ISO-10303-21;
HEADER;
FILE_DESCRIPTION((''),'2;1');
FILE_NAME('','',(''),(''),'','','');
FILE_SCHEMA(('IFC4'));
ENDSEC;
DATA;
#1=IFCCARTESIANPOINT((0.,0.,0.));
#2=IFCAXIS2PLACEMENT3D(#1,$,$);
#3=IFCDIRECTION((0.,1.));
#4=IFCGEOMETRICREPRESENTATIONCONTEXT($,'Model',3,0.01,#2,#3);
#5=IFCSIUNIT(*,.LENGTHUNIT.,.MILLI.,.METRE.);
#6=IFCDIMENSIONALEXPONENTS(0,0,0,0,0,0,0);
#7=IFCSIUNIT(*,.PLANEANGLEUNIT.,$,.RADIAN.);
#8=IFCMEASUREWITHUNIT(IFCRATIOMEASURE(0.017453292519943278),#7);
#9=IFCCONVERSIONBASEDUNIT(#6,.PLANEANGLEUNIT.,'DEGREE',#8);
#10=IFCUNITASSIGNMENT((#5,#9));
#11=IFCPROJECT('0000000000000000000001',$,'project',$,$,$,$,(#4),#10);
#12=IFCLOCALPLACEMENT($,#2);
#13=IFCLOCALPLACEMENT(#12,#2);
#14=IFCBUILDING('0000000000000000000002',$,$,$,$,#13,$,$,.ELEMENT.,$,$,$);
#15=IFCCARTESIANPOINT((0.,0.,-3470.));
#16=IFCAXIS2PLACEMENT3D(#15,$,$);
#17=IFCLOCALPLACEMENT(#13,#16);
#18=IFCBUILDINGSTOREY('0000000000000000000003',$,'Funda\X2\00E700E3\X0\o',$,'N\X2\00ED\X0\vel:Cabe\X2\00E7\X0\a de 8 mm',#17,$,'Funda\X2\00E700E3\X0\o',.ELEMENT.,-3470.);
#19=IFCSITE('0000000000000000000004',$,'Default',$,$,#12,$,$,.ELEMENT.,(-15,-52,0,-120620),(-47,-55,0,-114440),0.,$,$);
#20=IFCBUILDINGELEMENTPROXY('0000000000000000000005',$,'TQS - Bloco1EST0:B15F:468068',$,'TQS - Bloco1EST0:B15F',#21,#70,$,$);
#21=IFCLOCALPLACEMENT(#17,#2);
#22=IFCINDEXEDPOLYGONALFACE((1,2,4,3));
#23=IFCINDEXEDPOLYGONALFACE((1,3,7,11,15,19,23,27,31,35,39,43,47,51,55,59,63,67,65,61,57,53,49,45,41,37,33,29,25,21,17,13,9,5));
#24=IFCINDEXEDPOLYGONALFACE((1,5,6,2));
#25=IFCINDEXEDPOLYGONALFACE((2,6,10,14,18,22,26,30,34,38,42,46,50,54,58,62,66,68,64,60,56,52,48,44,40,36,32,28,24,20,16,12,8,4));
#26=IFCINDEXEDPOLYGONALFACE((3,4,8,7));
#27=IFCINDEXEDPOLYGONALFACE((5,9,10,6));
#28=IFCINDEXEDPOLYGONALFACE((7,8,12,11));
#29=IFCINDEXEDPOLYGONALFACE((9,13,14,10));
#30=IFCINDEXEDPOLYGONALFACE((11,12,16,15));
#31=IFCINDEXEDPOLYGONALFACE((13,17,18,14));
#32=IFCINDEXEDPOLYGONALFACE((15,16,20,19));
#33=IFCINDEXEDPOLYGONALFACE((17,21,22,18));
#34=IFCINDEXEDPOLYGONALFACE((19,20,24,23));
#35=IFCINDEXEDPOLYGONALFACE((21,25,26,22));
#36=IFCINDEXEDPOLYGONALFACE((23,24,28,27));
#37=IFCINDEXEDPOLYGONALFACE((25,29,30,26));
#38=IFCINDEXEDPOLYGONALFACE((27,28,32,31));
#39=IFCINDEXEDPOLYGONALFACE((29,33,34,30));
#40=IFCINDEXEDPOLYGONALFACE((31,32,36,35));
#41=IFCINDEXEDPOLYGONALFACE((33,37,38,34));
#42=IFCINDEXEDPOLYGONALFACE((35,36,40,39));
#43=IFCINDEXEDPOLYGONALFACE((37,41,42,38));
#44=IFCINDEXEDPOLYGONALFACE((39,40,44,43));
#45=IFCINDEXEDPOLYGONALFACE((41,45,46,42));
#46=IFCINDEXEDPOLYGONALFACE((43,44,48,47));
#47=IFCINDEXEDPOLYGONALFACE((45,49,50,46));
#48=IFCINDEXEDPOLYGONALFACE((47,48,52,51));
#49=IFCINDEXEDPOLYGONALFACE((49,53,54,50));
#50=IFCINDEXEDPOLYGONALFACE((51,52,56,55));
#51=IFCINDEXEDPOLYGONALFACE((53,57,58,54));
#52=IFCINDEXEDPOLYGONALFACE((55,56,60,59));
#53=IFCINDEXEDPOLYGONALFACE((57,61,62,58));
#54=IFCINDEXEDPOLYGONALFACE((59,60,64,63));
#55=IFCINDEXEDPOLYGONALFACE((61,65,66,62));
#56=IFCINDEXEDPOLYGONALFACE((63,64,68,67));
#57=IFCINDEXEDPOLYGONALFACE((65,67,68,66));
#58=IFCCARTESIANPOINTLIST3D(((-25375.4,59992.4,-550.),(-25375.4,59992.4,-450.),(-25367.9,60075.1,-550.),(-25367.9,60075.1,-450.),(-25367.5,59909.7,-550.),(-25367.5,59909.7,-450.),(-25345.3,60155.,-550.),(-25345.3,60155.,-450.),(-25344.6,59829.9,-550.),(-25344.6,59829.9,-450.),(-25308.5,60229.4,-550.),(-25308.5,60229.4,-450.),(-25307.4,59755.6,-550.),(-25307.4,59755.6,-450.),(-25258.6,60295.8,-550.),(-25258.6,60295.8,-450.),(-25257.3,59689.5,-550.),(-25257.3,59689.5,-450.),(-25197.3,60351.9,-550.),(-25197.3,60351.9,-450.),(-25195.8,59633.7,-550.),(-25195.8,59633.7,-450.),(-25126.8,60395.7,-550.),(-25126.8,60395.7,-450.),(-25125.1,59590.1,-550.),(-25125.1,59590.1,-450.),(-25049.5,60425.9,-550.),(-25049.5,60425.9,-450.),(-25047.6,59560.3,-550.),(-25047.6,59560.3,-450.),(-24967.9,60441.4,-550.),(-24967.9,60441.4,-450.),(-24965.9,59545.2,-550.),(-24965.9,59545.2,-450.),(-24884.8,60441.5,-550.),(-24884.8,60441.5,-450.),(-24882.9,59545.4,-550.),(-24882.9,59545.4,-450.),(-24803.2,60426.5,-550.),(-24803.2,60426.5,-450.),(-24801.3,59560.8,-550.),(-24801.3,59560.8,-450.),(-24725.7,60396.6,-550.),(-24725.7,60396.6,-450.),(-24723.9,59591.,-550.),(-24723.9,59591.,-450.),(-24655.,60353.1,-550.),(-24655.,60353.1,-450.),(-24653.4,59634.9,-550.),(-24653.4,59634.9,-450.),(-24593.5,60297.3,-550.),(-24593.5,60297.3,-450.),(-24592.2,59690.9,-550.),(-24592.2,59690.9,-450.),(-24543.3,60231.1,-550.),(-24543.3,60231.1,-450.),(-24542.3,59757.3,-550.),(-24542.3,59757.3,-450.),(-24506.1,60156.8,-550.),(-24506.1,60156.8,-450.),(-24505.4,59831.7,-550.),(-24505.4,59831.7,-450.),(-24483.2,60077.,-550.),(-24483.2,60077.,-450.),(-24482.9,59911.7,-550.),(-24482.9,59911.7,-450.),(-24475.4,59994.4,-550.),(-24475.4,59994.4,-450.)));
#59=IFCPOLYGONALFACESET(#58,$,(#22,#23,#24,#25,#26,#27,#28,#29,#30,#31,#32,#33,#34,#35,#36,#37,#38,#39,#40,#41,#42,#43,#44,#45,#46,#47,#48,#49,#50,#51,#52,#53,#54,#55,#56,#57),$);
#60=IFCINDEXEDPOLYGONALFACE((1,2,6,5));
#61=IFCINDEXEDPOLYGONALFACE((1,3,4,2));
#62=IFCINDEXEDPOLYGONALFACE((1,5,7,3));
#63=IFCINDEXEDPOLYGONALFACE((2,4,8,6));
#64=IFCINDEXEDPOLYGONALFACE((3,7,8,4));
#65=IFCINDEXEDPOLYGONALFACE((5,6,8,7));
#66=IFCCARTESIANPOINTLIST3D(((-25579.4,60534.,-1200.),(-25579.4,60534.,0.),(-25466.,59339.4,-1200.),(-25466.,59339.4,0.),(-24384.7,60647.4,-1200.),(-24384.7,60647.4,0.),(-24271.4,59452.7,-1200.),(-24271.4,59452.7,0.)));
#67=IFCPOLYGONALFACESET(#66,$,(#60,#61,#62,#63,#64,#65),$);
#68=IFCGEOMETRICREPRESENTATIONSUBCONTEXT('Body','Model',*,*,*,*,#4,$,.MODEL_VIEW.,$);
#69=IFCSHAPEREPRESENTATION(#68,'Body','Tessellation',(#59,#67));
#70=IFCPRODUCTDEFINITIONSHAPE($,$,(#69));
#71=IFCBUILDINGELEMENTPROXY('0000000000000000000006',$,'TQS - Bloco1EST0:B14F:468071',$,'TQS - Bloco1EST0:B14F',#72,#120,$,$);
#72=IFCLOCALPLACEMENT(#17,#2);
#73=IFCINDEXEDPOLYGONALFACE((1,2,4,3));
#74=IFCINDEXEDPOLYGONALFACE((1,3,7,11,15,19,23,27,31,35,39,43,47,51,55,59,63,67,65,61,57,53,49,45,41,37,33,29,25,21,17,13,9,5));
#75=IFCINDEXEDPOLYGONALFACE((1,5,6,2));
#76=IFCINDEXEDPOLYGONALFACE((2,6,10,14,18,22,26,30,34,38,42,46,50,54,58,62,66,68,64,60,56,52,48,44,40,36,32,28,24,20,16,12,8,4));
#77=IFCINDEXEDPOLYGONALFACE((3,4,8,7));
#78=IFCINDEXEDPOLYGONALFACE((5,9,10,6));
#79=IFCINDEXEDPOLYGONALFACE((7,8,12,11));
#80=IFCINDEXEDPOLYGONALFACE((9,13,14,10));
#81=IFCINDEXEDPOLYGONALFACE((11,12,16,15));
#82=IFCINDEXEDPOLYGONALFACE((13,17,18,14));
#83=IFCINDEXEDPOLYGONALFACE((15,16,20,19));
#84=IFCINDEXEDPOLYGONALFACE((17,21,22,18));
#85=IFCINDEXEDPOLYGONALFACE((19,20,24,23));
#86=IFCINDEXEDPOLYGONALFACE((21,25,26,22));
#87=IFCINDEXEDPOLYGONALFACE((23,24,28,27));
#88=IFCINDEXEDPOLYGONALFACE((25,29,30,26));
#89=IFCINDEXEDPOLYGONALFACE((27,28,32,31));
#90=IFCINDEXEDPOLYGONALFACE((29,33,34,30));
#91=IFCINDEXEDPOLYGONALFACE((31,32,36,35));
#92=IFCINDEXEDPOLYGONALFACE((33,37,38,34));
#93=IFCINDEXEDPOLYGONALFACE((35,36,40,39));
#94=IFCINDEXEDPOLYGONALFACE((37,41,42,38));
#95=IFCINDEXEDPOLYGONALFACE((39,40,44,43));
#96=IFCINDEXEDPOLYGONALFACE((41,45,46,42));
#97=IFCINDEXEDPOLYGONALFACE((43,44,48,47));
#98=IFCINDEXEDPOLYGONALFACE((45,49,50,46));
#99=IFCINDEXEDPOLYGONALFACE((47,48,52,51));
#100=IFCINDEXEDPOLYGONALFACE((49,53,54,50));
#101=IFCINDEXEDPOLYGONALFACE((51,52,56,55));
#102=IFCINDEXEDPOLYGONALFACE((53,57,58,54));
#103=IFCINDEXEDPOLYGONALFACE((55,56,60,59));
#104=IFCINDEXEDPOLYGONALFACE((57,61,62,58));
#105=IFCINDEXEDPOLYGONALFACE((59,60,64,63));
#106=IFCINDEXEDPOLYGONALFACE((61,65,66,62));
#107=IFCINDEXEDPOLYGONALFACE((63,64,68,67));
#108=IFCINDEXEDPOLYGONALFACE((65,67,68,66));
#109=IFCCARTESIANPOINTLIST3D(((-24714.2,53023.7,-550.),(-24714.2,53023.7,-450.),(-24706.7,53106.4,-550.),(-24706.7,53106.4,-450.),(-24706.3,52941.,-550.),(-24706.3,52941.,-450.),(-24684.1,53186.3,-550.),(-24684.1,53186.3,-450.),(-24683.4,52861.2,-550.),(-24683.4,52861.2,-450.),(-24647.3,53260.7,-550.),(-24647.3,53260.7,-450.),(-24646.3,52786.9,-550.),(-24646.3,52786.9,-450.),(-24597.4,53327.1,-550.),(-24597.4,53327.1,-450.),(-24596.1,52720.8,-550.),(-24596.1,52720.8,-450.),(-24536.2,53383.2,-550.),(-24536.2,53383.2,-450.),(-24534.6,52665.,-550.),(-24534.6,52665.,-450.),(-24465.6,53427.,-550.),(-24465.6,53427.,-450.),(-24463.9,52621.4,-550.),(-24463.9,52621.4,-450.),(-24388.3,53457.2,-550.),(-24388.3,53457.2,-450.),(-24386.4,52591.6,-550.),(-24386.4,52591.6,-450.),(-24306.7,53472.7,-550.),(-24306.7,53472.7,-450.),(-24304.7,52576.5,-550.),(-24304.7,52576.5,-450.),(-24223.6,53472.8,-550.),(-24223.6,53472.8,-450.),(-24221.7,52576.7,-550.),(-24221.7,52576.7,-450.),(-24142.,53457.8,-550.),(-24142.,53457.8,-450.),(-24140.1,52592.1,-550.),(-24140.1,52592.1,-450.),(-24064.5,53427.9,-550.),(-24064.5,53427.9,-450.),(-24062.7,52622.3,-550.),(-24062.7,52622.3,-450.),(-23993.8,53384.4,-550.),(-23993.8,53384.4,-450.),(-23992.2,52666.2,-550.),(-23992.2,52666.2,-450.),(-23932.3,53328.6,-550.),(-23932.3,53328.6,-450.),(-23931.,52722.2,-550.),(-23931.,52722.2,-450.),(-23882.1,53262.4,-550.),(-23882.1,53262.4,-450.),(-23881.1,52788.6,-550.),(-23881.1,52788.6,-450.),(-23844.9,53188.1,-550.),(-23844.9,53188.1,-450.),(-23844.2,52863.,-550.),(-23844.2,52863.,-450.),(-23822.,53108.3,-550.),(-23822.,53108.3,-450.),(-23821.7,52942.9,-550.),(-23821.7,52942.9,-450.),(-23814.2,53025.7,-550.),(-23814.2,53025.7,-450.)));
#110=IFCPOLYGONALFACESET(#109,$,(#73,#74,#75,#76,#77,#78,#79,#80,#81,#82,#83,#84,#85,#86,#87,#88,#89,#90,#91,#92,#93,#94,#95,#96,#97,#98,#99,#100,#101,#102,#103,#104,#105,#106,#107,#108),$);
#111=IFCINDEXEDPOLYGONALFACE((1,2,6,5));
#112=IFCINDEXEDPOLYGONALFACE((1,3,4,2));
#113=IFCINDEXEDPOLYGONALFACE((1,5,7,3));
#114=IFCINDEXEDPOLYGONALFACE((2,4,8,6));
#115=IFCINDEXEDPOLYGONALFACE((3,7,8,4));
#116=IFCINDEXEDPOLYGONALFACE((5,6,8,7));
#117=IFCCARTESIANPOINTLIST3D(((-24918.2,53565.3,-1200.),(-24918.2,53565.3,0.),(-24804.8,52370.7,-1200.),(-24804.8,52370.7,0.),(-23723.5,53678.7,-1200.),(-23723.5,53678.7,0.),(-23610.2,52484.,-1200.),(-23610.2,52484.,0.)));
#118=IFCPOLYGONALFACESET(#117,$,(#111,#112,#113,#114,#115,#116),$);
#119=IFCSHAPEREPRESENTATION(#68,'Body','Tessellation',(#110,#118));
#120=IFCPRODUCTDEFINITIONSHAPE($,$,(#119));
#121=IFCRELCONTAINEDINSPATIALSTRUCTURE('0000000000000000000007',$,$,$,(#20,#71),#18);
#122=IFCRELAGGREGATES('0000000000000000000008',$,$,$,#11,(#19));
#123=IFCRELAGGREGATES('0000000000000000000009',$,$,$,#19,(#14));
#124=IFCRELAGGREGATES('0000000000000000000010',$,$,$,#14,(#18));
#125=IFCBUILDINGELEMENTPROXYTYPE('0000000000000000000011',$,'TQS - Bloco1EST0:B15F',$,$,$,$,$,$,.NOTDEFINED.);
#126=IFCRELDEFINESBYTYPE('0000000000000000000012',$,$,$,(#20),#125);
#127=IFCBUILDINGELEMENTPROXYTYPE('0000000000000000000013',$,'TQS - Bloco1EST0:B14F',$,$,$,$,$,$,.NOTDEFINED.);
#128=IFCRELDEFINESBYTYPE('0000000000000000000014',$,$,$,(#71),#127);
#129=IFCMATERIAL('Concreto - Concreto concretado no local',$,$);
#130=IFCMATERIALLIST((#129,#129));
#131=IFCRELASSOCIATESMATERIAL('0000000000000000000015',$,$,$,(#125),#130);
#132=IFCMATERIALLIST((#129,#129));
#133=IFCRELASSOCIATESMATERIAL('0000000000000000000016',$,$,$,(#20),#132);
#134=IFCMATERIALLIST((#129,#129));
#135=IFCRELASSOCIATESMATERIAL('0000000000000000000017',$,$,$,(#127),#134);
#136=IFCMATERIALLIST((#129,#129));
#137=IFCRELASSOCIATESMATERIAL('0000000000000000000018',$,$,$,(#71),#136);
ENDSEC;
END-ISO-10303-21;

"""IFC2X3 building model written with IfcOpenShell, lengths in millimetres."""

from ifc_helpers import new_model, entity, si_unit, converted_unit, direction, frame, frame_2d, origin, origin_2d_with_axis, place, context, subcontext, project, spatial, rectangle, circle, extrude, source, transform, mapped, material, material_list, type_object, type_shapes, element, save


model = new_model("IFC2X3")

# Units and contexts
model_context = context("Model", 3, precision=0.01, world=origin(), true_north=direction((0.0, 1.0)))
body_context = subcontext(model_context, "Body", "Model", "MODEL_VIEW")
ifc_project = project(units=[si_unit("LENGTHUNIT", "METRE", prefix="MILLI"), converted_unit("PLANEANGLEUNIT", "DEGREE", entity("IfcRatioMeasure", 0.017453292519943278), si_unit("PLANEANGLEUNIT", "RADIAN"), dimensions=[0, 0, 0, 0, 0, 0, 0])], contexts=[model_context])

# Site, building, storey
site_placement = place(None, origin())
site = spatial("IfcSite", under=ifc_project, at=site_placement, Name="Default", CompositionType="ELEMENT", RefLatitude=(-15, -52, 0, -120620), RefLongitude=(-47, -55, 0, -114440), RefElevation=0.0)
building_placement = place(site_placement, origin())
building = spatial("IfcBuilding", under=site, at=building_placement, CompositionType="ELEMENT")
storey_placement = place(building_placement, frame((0.0, 0.0, -3470.0)))
storey = spatial("IfcBuildingStorey", under=building, at=storey_placement, Name="Fundação", ObjectType="Nível:Cabeça de 8 mm", LongName="Fundação", CompositionType="ELEMENT", Elevation=-3470.0)

# Building element proxies
ifc_material_1 = material(Name="Concreto - Concreto concretado no local")
ifc_material_list_1 = material_list([ifc_material_1, ifc_material_1])
ifc_material_list_2 = material_list([ifc_material_1, ifc_material_1])
building_element_proxy_type_1 = type_object("IfcBuildingElementProxyType", Name="TQS - Bloco1EST0:B15F", PredefinedType="NOTDEFINED", material=ifc_material_list_2)
shared_shape_1 = source(origin(), body_context, "Body", "SweptSolid", [
    extrude(circle(Radius=450.0, at=frame_2d((0.0, 0.0), x_axis=(1.0, 0.0))), frame((0.0, 0.0, -550.0)), (0.0, 0.0, 1.0), 100.0),
    extrude(rectangle(XDim=1200.0, YDim=1200.0, at=origin_2d_with_axis()), frame((0.0, 0.0, -1200.0), z_axis=(0.0, 0.0, 1.0), x_axis=(-1.0, 0.0, 0.0)), (0.0, 0.0, 1.0), 1200.0),
])
type_shapes(building_element_proxy_type_1, [shared_shape_1])
proxy_1_placement = place(storey_placement, frame((-24925.4, 59993.4, 0.0), z_axis=(0.0, 0.0, 1.0), x_axis=(-0.094456, 0.995529, 0.0)))
element("IfcBuildingElementProxy", 1, at=proxy_1_placement, inside=storey, type_object=building_element_proxy_type_1, material=ifc_material_list_1, Name="TQS - Bloco1EST0:B15F:468068", ObjectType="TQS - Bloco1EST0:B15F", context=body_context, shape_type="MappedRepresentation", body=[
    mapped(shared_shape_1, transform((0.0, 0.0, 0.0), scale=1.0)),
])
ifc_material_list_3 = material_list([ifc_material_1, ifc_material_1])
ifc_material_list_4 = material_list([ifc_material_1, ifc_material_1])
building_element_proxy_type_2 = type_object("IfcBuildingElementProxyType", Name="TQS - Bloco1EST0:B14F", PredefinedType="NOTDEFINED", material=ifc_material_list_4)
shared_shape_2 = source(origin(), body_context, "Body", "SweptSolid", [
    extrude(circle(Radius=450.0, at=frame_2d((0.0, 0.0), x_axis=(1.0, 0.0))), frame((0.0, 0.0, -550.0)), (0.0, 0.0, 1.0), 100.0),
    extrude(rectangle(XDim=1200.0, YDim=1200.0, at=origin_2d_with_axis()), frame((0.0, 0.0, -1200.0), z_axis=(0.0, 0.0, 1.0), x_axis=(-1.0, 0.0, 0.0)), (0.0, 0.0, 1.0), 1200.0),
])
type_shapes(building_element_proxy_type_2, [shared_shape_2])
proxy_2_placement = place(storey_placement, frame((-24264.2, 53024.7, 0.0), z_axis=(0.0, 0.0, 1.0), x_axis=(-0.094456, 0.995529, 0.0)))
element("IfcBuildingElementProxy", 2, at=proxy_2_placement, inside=storey, type_object=building_element_proxy_type_2, material=ifc_material_list_3, Name="TQS - Bloco1EST0:B14F:468071", ObjectType="TQS - Bloco1EST0:B14F", context=body_context, shape_type="MappedRepresentation", body=[
    mapped(shared_shape_2, transform((0.0, 0.0, 0.0), scale=1.0)),
])

save(model, "model.ifc")
